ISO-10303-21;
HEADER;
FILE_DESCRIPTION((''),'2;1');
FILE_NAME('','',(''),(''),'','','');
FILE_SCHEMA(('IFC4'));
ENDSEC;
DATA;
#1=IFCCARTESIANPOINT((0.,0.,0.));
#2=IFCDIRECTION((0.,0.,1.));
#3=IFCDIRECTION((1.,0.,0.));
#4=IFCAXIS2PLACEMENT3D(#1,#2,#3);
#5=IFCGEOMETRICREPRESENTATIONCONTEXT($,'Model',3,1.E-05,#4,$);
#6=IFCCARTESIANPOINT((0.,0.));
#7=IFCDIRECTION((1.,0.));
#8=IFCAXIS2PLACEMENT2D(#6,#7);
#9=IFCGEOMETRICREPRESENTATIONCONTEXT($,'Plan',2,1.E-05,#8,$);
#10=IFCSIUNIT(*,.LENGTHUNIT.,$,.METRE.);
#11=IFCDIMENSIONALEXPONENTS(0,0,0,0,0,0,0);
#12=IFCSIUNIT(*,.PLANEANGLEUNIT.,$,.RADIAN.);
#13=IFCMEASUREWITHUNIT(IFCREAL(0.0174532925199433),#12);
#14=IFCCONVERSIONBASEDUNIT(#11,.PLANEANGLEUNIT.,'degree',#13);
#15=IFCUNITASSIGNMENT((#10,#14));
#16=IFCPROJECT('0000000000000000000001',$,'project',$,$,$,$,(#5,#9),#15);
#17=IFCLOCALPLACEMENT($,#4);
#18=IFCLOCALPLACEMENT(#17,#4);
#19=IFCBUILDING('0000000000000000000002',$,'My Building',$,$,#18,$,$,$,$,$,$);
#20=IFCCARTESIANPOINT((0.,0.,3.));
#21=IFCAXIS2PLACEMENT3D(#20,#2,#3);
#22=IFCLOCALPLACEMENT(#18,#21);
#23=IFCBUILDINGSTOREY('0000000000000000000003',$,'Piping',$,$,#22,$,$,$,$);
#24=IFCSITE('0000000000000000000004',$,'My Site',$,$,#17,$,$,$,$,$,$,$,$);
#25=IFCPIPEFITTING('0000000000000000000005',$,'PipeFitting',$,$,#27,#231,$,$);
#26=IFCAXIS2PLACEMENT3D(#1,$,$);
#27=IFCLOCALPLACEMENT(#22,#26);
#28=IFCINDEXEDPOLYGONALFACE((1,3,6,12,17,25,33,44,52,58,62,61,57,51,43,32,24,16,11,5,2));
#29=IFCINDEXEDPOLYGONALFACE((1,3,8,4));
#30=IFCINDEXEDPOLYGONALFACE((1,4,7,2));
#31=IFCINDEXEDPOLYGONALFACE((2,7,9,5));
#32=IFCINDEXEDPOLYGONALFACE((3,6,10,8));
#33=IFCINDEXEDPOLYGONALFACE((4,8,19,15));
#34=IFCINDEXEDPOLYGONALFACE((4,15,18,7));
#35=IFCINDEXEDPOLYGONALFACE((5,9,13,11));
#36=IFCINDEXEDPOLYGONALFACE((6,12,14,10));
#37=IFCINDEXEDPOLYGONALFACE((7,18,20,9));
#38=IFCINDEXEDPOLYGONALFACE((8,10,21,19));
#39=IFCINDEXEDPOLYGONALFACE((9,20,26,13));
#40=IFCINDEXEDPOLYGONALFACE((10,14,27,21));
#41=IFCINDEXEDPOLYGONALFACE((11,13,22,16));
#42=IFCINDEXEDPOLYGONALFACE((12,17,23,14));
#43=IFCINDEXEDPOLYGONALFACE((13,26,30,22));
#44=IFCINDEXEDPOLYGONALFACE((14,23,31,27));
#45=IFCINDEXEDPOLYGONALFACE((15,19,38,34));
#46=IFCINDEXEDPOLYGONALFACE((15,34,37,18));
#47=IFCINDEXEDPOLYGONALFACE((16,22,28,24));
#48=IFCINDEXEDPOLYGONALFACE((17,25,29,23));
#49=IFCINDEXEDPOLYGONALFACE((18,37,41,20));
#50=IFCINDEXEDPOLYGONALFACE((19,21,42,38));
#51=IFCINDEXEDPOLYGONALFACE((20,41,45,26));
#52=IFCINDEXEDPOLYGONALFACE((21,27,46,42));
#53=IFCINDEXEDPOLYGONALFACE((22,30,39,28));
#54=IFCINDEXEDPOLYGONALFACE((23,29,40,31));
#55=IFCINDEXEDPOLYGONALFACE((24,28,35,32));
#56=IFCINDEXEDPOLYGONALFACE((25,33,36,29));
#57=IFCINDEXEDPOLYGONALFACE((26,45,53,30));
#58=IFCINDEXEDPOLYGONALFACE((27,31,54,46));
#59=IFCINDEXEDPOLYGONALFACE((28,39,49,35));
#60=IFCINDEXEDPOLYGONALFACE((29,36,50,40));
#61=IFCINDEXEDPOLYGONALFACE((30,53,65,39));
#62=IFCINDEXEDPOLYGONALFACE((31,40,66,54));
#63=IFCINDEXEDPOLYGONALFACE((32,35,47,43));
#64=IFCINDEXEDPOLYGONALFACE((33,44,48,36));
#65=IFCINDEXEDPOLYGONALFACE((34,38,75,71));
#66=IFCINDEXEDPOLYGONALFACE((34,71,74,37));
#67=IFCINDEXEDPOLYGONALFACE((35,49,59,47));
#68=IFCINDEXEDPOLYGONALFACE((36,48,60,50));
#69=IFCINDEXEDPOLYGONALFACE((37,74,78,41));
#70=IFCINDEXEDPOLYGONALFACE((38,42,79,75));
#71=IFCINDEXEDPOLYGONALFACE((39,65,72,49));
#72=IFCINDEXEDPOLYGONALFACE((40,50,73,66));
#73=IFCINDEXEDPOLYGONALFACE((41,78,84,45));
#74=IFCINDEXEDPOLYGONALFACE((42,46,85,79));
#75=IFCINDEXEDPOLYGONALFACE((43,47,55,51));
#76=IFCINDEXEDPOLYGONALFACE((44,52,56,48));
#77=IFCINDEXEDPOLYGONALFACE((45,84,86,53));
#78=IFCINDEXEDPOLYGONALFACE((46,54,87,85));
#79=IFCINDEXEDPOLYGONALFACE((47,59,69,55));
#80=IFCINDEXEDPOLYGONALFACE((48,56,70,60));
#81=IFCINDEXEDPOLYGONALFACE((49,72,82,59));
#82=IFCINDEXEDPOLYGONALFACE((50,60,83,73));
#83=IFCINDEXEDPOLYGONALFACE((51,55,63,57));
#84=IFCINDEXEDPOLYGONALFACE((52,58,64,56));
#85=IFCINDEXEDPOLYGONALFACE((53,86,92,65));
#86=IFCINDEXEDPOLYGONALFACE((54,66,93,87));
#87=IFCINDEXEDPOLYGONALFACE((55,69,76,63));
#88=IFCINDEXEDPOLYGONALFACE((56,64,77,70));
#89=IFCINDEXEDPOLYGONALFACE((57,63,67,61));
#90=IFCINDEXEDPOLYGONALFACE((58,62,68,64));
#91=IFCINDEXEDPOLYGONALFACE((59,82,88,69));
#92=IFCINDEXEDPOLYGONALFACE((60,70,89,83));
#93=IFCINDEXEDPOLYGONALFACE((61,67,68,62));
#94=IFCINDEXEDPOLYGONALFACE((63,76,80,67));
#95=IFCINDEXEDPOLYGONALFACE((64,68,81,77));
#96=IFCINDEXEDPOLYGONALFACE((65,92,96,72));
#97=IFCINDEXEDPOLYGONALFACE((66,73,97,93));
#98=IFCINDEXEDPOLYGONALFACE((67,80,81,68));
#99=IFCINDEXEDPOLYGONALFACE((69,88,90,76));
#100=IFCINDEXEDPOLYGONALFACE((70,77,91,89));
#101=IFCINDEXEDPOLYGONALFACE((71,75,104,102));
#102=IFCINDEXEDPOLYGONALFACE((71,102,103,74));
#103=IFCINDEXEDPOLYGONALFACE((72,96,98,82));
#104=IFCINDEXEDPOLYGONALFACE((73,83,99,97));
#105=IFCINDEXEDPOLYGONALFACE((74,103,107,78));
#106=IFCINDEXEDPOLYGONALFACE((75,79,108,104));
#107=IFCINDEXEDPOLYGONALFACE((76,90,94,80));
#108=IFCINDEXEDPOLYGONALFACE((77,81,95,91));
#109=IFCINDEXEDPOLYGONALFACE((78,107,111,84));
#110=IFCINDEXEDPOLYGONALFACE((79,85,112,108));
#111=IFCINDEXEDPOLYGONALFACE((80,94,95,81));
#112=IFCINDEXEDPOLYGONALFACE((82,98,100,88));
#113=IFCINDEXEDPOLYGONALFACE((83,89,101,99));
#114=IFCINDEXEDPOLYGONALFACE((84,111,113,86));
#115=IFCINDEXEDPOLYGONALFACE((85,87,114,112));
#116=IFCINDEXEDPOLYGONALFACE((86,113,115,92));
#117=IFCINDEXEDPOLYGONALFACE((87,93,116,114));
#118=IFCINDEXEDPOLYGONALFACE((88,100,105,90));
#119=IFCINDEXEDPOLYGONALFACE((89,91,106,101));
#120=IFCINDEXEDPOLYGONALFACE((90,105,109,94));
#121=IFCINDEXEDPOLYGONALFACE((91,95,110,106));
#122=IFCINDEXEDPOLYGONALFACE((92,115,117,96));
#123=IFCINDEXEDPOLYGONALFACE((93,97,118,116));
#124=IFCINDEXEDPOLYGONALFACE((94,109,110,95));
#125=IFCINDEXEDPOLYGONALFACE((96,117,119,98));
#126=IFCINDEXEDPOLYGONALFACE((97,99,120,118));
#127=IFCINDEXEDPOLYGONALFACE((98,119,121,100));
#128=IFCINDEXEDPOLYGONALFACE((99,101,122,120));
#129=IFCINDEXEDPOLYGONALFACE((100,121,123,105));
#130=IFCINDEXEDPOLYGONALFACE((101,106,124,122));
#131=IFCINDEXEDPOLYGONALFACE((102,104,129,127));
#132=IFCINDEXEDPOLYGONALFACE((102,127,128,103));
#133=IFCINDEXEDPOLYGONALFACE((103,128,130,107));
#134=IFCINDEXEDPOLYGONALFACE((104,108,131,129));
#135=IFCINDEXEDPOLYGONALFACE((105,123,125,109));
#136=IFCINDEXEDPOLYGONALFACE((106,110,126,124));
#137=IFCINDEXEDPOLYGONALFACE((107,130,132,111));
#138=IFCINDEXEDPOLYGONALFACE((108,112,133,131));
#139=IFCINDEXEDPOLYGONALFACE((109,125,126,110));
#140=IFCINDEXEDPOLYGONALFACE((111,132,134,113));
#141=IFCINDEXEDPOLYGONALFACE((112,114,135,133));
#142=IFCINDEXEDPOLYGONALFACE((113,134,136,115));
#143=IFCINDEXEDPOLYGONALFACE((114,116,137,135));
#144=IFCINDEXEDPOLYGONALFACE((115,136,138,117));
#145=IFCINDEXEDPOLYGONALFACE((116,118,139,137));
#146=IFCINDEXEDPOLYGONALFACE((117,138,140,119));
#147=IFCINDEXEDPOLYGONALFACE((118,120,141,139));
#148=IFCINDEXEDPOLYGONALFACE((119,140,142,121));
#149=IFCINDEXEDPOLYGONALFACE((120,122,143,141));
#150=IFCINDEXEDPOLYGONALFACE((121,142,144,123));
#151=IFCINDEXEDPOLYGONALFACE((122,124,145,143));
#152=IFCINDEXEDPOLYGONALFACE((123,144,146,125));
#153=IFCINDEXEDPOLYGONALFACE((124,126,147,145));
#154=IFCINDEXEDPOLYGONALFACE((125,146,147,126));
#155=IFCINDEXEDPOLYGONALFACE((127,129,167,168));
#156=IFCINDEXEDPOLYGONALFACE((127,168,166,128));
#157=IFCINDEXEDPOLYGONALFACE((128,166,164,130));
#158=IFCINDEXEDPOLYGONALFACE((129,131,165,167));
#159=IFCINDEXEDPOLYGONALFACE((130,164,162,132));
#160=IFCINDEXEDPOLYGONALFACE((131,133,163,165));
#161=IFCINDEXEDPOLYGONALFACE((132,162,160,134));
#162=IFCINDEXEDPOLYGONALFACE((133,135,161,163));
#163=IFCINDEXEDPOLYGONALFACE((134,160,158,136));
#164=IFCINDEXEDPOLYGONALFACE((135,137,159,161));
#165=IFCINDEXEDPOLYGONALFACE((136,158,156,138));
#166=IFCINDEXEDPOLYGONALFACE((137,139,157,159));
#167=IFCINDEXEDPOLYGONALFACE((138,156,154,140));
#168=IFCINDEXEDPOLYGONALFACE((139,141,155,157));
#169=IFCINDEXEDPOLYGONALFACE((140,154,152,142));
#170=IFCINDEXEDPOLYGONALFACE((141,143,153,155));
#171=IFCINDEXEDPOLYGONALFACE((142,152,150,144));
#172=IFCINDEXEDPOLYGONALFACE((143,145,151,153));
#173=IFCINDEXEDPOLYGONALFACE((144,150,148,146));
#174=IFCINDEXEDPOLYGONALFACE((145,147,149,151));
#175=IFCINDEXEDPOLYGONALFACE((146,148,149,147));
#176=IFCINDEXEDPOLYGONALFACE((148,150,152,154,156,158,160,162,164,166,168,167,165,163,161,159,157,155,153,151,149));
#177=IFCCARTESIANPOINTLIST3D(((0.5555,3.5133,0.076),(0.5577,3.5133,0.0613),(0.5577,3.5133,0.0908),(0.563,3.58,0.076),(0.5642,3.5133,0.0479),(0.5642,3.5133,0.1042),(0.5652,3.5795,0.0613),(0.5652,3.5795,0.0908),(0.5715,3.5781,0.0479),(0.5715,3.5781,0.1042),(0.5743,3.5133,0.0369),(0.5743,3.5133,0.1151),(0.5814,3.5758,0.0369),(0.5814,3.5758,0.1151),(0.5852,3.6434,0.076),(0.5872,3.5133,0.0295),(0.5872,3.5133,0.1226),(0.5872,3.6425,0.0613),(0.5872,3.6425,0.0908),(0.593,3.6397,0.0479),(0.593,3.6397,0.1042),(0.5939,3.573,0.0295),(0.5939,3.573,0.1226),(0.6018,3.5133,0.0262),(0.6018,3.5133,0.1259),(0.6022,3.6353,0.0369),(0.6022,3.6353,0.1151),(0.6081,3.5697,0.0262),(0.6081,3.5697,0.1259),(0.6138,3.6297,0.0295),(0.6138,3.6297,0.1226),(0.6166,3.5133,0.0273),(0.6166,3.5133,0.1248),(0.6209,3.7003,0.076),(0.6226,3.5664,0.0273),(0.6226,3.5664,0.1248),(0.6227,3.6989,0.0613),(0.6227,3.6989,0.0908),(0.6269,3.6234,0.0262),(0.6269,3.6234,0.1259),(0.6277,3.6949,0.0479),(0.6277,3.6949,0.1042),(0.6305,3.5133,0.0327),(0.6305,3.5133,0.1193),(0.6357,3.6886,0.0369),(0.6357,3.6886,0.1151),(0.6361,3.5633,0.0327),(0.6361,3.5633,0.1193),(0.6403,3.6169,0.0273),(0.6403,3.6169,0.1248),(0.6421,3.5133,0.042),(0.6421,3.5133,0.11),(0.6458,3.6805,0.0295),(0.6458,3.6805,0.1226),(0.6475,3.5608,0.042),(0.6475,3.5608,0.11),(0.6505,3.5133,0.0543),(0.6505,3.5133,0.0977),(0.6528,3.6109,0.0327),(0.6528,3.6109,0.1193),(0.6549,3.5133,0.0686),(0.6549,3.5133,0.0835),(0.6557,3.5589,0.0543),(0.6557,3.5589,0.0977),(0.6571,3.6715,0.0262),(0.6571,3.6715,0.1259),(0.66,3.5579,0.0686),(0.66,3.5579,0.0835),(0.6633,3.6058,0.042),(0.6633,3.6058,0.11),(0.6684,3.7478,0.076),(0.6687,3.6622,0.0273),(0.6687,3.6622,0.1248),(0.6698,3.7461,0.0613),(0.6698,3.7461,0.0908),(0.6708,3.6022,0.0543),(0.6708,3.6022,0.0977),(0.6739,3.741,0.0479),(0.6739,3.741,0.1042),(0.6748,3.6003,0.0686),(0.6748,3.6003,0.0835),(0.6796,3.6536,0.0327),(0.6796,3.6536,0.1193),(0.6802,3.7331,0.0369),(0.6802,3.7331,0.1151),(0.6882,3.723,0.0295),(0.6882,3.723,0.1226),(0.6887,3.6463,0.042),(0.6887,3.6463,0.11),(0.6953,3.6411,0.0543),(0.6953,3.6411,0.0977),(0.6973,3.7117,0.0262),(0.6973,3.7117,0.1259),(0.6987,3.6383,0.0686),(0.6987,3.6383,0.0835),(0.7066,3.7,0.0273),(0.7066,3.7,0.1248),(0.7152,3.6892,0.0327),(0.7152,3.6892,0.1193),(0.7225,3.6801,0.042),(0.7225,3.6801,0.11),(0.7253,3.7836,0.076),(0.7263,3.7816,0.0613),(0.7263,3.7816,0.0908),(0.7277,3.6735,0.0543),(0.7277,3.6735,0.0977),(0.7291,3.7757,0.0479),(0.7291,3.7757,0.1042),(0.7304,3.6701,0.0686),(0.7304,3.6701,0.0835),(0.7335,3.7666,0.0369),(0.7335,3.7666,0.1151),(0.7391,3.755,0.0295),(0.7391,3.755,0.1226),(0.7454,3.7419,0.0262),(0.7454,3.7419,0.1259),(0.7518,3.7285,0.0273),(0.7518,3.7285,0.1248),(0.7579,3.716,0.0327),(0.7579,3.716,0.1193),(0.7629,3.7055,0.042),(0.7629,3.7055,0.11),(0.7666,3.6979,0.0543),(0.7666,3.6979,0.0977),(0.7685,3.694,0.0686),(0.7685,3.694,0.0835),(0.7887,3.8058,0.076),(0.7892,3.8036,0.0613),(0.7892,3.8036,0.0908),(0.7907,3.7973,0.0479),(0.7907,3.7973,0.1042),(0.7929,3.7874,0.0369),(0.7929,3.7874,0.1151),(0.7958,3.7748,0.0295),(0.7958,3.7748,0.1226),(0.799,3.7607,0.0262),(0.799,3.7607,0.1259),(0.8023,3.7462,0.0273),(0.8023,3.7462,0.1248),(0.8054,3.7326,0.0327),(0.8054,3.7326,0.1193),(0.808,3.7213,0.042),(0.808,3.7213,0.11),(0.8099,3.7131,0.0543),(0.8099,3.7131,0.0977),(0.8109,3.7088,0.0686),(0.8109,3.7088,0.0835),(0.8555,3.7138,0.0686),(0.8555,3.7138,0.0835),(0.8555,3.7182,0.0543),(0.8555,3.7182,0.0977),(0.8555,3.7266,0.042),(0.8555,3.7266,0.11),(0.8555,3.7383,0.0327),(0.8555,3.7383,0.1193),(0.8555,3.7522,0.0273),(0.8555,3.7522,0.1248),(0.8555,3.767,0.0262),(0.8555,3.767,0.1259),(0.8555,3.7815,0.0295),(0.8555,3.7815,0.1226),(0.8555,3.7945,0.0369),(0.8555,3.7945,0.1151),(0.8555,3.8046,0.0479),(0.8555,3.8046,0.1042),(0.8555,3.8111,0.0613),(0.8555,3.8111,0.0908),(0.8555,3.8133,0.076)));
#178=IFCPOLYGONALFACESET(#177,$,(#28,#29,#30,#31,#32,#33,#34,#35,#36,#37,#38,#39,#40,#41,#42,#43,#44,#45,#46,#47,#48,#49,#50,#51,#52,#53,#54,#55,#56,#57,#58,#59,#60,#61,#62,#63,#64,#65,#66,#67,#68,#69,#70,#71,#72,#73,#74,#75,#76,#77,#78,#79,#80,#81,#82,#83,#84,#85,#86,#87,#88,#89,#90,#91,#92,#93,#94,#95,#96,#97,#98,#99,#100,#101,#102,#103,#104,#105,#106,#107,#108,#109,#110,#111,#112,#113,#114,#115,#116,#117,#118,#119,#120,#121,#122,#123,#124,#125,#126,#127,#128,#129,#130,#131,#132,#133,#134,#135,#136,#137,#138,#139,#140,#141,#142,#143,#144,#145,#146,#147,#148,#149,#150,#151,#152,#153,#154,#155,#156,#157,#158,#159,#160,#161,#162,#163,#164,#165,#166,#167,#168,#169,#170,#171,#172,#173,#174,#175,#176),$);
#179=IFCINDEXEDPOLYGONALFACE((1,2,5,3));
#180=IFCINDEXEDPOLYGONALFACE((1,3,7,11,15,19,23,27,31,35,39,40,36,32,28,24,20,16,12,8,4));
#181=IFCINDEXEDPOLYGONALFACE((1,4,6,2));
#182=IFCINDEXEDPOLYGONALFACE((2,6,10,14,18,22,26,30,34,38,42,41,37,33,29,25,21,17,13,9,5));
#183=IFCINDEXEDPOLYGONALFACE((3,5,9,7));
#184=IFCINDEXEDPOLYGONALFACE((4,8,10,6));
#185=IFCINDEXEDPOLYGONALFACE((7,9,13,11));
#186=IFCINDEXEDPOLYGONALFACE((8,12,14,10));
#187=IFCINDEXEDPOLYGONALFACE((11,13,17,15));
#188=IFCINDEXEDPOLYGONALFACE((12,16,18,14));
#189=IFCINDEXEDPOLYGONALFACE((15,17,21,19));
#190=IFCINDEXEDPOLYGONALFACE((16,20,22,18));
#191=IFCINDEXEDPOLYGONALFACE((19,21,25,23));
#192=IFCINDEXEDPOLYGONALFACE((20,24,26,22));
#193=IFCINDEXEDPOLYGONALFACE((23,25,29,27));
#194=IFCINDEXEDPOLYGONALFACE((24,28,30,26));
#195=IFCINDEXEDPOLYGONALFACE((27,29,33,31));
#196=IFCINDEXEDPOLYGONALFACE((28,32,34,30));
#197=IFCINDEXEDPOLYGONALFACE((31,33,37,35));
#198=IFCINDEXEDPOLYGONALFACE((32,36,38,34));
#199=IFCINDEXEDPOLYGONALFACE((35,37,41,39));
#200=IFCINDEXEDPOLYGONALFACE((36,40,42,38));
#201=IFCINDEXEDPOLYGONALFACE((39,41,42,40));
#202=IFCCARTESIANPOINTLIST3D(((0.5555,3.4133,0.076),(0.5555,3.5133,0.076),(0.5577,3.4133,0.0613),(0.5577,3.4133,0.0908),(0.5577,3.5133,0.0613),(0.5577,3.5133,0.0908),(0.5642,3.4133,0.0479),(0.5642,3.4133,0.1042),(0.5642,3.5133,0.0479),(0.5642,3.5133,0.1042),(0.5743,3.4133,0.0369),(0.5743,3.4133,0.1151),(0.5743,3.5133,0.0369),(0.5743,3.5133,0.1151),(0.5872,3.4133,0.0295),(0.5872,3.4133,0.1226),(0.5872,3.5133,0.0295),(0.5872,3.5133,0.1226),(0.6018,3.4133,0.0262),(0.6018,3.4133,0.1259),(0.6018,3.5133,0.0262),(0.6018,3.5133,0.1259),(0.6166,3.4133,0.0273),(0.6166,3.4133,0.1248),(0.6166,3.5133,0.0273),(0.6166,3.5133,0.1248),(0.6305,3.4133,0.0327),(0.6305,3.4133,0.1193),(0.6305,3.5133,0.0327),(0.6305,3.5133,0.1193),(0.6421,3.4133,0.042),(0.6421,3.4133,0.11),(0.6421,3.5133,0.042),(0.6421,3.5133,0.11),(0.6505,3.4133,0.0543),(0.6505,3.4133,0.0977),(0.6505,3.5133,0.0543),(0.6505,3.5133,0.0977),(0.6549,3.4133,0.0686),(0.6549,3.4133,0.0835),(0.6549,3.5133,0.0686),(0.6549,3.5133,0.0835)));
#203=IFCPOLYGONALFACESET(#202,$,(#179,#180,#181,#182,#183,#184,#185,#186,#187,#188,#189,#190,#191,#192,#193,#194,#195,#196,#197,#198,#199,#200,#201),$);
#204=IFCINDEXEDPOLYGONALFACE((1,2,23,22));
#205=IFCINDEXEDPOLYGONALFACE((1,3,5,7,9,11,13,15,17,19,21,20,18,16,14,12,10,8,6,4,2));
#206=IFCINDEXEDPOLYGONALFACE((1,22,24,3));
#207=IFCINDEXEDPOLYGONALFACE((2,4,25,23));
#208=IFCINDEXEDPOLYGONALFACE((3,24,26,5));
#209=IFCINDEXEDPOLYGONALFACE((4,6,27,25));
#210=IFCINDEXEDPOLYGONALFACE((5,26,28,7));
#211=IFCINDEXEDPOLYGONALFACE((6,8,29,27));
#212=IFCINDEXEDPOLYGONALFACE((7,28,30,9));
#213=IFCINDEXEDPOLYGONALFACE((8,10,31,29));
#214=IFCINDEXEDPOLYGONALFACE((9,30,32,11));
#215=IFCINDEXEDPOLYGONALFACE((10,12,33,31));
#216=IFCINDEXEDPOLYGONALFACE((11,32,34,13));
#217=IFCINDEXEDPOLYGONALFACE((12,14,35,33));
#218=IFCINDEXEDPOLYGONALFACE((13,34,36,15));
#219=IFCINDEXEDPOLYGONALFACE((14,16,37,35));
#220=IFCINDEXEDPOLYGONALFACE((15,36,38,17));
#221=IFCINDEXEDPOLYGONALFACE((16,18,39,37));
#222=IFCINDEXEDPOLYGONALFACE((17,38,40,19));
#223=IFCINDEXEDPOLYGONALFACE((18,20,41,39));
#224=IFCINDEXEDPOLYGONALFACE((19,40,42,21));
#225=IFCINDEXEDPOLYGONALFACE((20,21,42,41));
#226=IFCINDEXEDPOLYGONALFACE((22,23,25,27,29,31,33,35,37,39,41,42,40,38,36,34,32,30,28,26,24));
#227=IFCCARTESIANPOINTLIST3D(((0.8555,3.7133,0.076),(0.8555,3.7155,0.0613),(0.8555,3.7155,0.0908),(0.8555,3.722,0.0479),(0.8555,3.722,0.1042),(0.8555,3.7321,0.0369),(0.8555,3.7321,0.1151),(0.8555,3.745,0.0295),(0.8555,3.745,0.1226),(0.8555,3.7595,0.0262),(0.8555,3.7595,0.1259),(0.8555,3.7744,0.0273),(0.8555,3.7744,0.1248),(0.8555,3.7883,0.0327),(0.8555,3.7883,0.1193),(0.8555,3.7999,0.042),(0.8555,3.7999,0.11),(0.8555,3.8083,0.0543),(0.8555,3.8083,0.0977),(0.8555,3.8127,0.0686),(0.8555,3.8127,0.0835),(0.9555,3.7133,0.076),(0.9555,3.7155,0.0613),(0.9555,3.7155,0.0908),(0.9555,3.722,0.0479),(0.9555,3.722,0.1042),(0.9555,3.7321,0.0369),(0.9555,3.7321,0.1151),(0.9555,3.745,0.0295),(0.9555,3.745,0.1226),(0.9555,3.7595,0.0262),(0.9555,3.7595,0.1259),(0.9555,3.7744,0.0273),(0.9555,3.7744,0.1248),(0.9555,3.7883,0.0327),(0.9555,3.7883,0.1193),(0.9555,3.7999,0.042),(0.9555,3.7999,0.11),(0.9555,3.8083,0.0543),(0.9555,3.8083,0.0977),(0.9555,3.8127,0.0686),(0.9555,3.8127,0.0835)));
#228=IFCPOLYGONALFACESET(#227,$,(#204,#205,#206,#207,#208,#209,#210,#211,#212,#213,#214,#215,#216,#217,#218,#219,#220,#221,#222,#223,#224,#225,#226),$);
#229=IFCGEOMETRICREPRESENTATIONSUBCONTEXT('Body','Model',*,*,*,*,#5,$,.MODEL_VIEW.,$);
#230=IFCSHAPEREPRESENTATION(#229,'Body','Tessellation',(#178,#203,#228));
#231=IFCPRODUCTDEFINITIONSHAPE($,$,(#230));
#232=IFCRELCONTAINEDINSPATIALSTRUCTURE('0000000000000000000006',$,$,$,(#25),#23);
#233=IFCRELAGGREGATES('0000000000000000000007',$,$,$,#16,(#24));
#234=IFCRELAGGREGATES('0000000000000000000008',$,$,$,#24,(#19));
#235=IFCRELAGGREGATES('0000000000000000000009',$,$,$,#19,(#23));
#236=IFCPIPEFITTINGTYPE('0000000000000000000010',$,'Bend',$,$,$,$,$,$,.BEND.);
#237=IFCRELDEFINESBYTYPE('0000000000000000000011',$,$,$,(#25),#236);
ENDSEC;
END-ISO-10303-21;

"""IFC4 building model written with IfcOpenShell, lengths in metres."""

from ifc_helpers import new_model, entity, si_unit, converted_unit, frame, origin_with_axes, origin_2d_with_axis, place, context, subcontext, project, spatial, circle, extrude, source, transform, mapped, type_object, type_shapes, element, save


model = new_model("IFC4")

# Units and contexts
model_context = context("Model", 3, precision=1e-05, world=origin_with_axes())
plan_context = context("Plan", 2, precision=1e-05, world=origin_2d_with_axis())
body_context = subcontext(model_context, "Body", "Model", "MODEL_VIEW")
ifc_project = project(units=[si_unit("LENGTHUNIT", "METRE"), converted_unit("PLANEANGLEUNIT", "degree", entity("IfcReal", 0.0174532925199433), si_unit("PLANEANGLEUNIT", "RADIAN"), dimensions=[0, 0, 0, 0, 0, 0, 0])], contexts=[model_context, plan_context])

# Site, building, storey
site_placement = place(None, origin_with_axes())
site = spatial("IfcSite", under=ifc_project, at=site_placement, Name="My Site")
building_placement = place(site_placement, origin_with_axes())
building = spatial("IfcBuilding", under=site, at=building_placement, Name="My Building")
storey_placement = place(building_placement, frame((0.0, 0.0, 3.0), z_axis=(0.0, 0.0, 1.0), x_axis=(1.0, 0.0, 0.0)))
storey = spatial("IfcBuildingStorey", under=building, at=storey_placement, Name="Piping")

# Pipe fitting
pipe_fitting_type_1 = type_object("IfcPipeFittingType", Name="Bend", PredefinedType="BEND")
shared_shape_1 = source(origin_with_axes(), body_context, "Body", "SolidModel", [
    entity("IfcSweptDiskSolid", entity("IfcIndexedPolyCurve", entity("IfcCartesianPointList3D", [[0.0, 0.0, 0.1], [-0.0732, 0.0, 0.2768], [-0.25, 0.0, 0.35]]), [entity("IfcArcIndex", [1, 2, 3])]), 0.05),
    extrude(circle(Radius=0.05), origin_with_axes(), (0.0, 0.0, 1.0), 0.1),
    extrude(circle(Radius=0.05), frame((-0.25, 0.0, 0.35), z_axis=(-1.0, 0.0, 0.0), x_axis=(0.0, 0.0, -1.0)), (0.0, 0.0, 1.0), 0.1),
])
type_shapes(pipe_fitting_type_1, [shared_shape_1])
pipe_fitting_placement = place(storey_placement, frame((0.6055, 3.4133, 0.076), z_axis=(0.0, 1.0, 0.0), x_axis=(-1.0, 0.0, 0.0)))
element("IfcPipeFitting", 1, at=pipe_fitting_placement, inside=storey, type_object=pipe_fitting_type_1, Name="PipeFitting", context=body_context, shape_type="MappedRepresentation", body=[
    mapped(shared_shape_1, transform((0.0, 0.0, 0.0), x_axis=(1.0, 0.0, 0.0), y_axis=(0.0, 1.0, 0.0), z_axis=(0.0, 0.0, 1.0), scale=1.0)),
])

save(model, "model.ifc")
